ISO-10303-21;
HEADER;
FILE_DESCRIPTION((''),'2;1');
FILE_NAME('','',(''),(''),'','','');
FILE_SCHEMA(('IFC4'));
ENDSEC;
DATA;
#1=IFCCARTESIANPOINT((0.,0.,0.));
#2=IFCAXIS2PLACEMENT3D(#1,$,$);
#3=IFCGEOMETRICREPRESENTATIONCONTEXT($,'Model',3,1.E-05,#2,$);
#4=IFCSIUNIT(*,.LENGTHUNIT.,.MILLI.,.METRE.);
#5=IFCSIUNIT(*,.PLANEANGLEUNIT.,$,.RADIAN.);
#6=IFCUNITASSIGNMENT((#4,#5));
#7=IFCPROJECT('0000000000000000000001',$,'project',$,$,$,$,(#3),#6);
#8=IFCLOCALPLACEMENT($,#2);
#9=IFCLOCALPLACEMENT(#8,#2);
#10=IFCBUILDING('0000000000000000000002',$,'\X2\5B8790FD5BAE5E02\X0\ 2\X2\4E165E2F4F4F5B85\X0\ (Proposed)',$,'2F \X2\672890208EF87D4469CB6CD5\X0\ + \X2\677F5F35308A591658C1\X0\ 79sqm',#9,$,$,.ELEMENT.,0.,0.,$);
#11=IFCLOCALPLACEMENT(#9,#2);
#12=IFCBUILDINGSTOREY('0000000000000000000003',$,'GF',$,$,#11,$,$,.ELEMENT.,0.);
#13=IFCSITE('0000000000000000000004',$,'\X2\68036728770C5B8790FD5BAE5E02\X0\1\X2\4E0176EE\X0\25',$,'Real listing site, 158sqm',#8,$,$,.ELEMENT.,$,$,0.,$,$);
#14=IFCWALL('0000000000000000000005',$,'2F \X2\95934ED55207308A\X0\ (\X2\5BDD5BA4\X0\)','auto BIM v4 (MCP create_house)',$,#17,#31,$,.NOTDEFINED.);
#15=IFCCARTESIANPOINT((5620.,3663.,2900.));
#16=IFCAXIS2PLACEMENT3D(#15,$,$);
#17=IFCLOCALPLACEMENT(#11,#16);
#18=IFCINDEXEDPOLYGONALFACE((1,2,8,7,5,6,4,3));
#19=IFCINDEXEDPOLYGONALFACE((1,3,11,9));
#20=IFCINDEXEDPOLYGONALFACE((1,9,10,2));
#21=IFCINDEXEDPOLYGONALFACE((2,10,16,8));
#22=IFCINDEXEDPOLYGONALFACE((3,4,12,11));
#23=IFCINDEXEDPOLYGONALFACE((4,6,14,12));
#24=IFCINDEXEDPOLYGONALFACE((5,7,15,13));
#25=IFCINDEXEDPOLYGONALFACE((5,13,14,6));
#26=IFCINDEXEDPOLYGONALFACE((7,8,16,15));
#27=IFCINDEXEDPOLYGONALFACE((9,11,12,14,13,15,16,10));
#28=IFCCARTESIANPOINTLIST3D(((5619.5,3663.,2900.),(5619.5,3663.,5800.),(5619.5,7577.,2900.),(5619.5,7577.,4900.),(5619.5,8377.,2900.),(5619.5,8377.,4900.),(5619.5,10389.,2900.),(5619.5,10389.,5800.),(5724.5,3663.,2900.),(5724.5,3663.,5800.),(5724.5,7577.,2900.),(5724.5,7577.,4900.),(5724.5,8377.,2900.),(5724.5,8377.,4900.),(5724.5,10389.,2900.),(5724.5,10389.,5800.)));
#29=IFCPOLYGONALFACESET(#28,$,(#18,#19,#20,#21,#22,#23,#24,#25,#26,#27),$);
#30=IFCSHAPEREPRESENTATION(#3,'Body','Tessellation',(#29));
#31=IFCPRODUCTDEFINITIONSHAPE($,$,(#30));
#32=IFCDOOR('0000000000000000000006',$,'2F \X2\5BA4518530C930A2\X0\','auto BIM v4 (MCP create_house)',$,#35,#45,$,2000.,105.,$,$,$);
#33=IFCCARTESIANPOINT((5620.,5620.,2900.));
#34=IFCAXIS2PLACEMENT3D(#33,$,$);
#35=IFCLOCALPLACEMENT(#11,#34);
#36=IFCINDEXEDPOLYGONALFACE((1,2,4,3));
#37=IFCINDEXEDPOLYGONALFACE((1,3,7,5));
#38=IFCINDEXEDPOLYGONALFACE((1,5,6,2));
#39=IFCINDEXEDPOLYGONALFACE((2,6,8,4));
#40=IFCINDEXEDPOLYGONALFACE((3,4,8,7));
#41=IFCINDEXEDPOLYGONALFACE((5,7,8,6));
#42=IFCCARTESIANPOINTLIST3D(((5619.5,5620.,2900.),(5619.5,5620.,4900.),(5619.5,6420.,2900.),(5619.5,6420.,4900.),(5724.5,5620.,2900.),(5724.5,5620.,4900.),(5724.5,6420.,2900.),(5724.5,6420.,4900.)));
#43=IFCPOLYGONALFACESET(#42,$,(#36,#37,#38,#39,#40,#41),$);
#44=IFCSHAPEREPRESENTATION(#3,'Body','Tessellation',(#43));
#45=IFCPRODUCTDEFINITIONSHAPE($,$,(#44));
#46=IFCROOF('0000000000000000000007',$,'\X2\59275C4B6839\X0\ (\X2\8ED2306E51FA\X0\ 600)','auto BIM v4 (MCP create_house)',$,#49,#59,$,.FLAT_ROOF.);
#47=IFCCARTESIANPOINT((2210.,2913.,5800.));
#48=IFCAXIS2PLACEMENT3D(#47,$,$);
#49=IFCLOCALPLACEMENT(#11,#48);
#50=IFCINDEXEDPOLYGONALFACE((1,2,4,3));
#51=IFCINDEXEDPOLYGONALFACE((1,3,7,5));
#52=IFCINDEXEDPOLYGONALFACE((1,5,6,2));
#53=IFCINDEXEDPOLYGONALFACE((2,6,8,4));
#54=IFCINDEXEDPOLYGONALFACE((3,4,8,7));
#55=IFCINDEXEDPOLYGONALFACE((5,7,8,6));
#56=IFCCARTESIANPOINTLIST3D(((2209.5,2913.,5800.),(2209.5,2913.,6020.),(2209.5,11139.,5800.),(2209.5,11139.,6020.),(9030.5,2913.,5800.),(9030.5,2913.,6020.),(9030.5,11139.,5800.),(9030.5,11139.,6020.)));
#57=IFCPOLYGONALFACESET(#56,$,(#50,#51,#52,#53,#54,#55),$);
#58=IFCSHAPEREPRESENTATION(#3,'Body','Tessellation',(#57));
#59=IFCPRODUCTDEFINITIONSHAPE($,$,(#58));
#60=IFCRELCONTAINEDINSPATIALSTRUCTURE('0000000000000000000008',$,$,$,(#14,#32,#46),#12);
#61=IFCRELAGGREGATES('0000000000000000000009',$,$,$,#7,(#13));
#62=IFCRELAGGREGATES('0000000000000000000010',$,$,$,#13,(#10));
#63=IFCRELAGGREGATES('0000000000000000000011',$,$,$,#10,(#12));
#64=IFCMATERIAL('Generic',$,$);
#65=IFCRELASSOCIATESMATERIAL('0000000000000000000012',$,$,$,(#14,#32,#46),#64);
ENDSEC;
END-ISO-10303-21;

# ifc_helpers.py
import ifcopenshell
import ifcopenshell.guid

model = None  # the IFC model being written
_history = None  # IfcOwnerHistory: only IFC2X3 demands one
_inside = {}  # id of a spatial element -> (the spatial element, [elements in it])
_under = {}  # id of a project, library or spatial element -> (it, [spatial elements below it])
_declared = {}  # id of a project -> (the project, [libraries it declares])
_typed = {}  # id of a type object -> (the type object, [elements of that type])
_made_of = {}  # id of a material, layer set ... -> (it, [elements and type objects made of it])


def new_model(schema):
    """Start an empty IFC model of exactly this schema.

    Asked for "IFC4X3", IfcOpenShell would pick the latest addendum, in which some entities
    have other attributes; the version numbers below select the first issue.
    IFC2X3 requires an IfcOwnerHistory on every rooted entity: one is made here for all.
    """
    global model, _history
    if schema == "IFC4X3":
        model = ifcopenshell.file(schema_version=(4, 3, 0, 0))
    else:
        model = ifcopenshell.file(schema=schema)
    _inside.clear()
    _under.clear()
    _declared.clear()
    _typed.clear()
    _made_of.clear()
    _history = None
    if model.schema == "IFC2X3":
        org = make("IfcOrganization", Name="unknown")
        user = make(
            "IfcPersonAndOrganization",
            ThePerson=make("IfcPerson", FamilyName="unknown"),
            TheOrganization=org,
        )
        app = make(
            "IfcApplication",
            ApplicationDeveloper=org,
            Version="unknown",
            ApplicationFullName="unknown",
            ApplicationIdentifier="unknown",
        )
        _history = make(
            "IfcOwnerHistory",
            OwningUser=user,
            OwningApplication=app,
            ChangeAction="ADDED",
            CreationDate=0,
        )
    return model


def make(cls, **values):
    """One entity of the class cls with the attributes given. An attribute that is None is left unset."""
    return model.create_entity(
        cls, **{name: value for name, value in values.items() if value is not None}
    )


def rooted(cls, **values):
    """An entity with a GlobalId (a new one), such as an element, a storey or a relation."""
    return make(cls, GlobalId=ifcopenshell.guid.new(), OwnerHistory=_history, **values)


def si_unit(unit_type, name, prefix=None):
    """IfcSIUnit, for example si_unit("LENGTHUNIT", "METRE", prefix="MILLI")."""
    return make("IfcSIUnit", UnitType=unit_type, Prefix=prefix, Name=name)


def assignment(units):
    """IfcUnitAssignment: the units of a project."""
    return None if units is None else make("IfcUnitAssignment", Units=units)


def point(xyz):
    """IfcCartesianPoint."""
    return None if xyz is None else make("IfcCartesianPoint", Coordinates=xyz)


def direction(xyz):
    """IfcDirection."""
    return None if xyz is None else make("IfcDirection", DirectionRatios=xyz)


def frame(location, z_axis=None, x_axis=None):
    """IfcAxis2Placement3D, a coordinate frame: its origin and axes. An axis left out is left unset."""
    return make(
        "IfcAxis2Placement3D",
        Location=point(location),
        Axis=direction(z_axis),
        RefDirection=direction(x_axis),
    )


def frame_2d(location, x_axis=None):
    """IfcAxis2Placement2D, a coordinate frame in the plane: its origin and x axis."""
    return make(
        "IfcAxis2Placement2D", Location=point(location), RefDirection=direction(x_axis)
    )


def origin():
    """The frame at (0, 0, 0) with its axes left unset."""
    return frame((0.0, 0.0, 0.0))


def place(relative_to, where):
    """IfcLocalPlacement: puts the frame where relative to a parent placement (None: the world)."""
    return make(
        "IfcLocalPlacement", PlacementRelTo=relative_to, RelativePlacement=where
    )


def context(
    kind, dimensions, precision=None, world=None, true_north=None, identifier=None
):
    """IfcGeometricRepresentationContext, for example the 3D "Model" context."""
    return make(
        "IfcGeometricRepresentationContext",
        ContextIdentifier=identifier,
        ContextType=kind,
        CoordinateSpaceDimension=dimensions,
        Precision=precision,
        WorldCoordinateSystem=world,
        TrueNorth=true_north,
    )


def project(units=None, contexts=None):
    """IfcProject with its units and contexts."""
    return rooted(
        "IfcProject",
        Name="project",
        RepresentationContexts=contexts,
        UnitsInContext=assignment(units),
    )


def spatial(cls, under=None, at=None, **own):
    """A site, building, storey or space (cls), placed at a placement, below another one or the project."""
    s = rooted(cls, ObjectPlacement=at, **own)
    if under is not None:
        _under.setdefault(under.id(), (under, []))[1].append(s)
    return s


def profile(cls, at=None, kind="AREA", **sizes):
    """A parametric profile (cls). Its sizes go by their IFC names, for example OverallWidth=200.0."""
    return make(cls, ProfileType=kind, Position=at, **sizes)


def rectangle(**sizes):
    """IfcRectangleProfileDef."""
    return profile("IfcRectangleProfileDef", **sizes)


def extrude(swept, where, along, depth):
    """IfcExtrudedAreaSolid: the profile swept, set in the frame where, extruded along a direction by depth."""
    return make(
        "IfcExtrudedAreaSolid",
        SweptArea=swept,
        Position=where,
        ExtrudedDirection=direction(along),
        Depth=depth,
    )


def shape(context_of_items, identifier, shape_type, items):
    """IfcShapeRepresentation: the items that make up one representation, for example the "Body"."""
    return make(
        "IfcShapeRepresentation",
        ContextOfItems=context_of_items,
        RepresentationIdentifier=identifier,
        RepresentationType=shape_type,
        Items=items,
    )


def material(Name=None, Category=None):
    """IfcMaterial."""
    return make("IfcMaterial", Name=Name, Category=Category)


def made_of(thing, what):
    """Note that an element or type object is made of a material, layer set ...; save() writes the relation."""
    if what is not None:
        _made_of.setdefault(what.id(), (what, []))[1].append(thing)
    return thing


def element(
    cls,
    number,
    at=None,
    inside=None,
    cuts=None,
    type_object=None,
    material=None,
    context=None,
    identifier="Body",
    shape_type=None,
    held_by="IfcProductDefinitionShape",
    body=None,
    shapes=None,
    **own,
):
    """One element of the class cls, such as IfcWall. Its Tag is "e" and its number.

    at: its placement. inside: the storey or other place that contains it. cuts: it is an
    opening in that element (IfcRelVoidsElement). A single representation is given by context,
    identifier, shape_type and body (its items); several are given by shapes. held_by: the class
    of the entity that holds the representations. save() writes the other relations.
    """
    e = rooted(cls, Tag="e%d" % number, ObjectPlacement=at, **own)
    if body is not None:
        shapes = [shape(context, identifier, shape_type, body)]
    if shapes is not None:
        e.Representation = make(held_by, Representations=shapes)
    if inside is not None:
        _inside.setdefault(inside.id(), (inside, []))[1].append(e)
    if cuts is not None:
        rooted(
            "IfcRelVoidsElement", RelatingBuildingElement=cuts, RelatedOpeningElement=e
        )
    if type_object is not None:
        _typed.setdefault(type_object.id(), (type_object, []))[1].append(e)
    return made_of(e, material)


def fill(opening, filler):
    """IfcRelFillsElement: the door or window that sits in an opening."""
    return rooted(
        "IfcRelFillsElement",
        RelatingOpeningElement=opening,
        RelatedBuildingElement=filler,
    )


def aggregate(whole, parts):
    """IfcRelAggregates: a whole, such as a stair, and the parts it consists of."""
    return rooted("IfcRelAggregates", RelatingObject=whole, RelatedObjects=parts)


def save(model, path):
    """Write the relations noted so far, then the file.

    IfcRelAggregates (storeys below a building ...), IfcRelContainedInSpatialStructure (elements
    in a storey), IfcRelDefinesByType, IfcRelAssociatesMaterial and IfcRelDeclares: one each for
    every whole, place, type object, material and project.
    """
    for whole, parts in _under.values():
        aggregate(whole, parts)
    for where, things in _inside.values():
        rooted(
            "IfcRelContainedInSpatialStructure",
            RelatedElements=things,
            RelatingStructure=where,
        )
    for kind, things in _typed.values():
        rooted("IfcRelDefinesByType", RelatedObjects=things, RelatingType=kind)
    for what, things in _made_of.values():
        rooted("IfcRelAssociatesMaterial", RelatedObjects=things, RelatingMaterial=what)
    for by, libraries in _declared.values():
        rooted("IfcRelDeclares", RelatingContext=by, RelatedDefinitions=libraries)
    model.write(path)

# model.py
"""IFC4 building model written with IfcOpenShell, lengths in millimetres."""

from ifc_helpers import new_model, si_unit, frame, frame_2d, origin, place, context, project, spatial, rectangle, extrude, material, element, fill, save


model = new_model("IFC4")

# Units and contexts
model_context = context("Model", 3, precision=1e-05, world=origin())
ifc_project = project(units=[si_unit("LENGTHUNIT", "METRE", prefix="MILLI"), si_unit("PLANEANGLEUNIT", "RADIAN")], contexts=[model_context])

# Site, building, storey
site_placement = place(None, origin())
site = spatial("IfcSite", under=ifc_project, at=site_placement, Name="栃木県宇都宮市1丁目25", ObjectType="Real listing site, 158sqm", CompositionType="ELEMENT", RefElevation=0.0)
building_placement = place(site_placement, origin())
building = spatial("IfcBuilding", under=site, at=building_placement, Name="宇都宮市 2世帯住宅 (Proposed)", ObjectType="2F 木造軸組構法 + 板張り外壁 79sqm", CompositionType="ELEMENT", ElevationOfRefHeight=0.0, ElevationOfTerrain=0.0)
storey_placement = place(building_placement, origin())
storey = spatial("IfcBuildingStorey", under=building, at=storey_placement, Name="GF", CompositionType="ELEMENT", Elevation=0.0)

# Shared definitions
ifc_material = material(Name="Generic")

# Wall, opening, door
wall_1_placement = place(storey_placement, frame((5620.0, 3663.0, 2900.0)))
wall_1 = element("IfcWall", 1, at=wall_1_placement, inside=storey, material=ifc_material, Name="2F 間仕切り (寝室)", Description="auto BIM v4 (MCP create_house)", PredefinedType="NOTDEFINED", context=model_context, shape_type="SweptSolid", body=[
    extrude(rectangle(XDim=105.0, YDim=6726.0, at=frame_2d((52.0, 3363.0))), frame((5620.0, 3663.0, 2900.0)), (0.0, 0.0, 1.0), 2900.0),
])
opening_1_placement = place(storey_placement, frame((5620.0, 5620.0, 2900.0)))
opening_1 = element("IfcOpeningElement", 2, at=opening_1_placement, cuts=wall_1, PredefinedType="NOTDEFINED", context=model_context, shape_type="SweptSolid", body=[
    extrude(rectangle(XDim=105.0, YDim=800.0, at=frame_2d((52.0, 400.0))), frame((5620.0, 5620.0, 2900.0)), (0.0, 0.0, 1.0), 2000.0),
])
door_1_placement = place(storey_placement, frame((5620.0, 5620.0, 2900.0)))
door_1 = element("IfcDoor", 3, at=door_1_placement, inside=storey, material=ifc_material, Name="2F 室内ドア", Description="auto BIM v4 (MCP create_house)", OverallHeight=2000.0, OverallWidth=105.0, context=model_context, shape_type="SweptSolid", body=[
    extrude(rectangle(XDim=105.0, YDim=800.0, at=frame_2d((52.0, 400.0))), frame((5620.0, 5620.0, 2900.0)), (0.0, 0.0, 1.0), 2000.0),
])
fill(opening_1, door_1)

# Roof
roof_placement = place(storey_placement, frame((2210.0, 2913.0, 5800.0)))
element("IfcRoof", 4, at=roof_placement, inside=storey, material=ifc_material, Name="大屋根 (軒の出 600)", Description="auto BIM v4 (MCP create_house)", PredefinedType="FLAT_ROOF", context=model_context, shape_type="SweptSolid", body=[
    extrude(rectangle(XDim=6821.0, YDim=8226.0, at=frame_2d((3410.0, 4113.0))), frame((2210.0, 2913.0, 5800.0)), (0.0, 0.0, 1.0), 220.0),
])

save(model, "model.ifc")
